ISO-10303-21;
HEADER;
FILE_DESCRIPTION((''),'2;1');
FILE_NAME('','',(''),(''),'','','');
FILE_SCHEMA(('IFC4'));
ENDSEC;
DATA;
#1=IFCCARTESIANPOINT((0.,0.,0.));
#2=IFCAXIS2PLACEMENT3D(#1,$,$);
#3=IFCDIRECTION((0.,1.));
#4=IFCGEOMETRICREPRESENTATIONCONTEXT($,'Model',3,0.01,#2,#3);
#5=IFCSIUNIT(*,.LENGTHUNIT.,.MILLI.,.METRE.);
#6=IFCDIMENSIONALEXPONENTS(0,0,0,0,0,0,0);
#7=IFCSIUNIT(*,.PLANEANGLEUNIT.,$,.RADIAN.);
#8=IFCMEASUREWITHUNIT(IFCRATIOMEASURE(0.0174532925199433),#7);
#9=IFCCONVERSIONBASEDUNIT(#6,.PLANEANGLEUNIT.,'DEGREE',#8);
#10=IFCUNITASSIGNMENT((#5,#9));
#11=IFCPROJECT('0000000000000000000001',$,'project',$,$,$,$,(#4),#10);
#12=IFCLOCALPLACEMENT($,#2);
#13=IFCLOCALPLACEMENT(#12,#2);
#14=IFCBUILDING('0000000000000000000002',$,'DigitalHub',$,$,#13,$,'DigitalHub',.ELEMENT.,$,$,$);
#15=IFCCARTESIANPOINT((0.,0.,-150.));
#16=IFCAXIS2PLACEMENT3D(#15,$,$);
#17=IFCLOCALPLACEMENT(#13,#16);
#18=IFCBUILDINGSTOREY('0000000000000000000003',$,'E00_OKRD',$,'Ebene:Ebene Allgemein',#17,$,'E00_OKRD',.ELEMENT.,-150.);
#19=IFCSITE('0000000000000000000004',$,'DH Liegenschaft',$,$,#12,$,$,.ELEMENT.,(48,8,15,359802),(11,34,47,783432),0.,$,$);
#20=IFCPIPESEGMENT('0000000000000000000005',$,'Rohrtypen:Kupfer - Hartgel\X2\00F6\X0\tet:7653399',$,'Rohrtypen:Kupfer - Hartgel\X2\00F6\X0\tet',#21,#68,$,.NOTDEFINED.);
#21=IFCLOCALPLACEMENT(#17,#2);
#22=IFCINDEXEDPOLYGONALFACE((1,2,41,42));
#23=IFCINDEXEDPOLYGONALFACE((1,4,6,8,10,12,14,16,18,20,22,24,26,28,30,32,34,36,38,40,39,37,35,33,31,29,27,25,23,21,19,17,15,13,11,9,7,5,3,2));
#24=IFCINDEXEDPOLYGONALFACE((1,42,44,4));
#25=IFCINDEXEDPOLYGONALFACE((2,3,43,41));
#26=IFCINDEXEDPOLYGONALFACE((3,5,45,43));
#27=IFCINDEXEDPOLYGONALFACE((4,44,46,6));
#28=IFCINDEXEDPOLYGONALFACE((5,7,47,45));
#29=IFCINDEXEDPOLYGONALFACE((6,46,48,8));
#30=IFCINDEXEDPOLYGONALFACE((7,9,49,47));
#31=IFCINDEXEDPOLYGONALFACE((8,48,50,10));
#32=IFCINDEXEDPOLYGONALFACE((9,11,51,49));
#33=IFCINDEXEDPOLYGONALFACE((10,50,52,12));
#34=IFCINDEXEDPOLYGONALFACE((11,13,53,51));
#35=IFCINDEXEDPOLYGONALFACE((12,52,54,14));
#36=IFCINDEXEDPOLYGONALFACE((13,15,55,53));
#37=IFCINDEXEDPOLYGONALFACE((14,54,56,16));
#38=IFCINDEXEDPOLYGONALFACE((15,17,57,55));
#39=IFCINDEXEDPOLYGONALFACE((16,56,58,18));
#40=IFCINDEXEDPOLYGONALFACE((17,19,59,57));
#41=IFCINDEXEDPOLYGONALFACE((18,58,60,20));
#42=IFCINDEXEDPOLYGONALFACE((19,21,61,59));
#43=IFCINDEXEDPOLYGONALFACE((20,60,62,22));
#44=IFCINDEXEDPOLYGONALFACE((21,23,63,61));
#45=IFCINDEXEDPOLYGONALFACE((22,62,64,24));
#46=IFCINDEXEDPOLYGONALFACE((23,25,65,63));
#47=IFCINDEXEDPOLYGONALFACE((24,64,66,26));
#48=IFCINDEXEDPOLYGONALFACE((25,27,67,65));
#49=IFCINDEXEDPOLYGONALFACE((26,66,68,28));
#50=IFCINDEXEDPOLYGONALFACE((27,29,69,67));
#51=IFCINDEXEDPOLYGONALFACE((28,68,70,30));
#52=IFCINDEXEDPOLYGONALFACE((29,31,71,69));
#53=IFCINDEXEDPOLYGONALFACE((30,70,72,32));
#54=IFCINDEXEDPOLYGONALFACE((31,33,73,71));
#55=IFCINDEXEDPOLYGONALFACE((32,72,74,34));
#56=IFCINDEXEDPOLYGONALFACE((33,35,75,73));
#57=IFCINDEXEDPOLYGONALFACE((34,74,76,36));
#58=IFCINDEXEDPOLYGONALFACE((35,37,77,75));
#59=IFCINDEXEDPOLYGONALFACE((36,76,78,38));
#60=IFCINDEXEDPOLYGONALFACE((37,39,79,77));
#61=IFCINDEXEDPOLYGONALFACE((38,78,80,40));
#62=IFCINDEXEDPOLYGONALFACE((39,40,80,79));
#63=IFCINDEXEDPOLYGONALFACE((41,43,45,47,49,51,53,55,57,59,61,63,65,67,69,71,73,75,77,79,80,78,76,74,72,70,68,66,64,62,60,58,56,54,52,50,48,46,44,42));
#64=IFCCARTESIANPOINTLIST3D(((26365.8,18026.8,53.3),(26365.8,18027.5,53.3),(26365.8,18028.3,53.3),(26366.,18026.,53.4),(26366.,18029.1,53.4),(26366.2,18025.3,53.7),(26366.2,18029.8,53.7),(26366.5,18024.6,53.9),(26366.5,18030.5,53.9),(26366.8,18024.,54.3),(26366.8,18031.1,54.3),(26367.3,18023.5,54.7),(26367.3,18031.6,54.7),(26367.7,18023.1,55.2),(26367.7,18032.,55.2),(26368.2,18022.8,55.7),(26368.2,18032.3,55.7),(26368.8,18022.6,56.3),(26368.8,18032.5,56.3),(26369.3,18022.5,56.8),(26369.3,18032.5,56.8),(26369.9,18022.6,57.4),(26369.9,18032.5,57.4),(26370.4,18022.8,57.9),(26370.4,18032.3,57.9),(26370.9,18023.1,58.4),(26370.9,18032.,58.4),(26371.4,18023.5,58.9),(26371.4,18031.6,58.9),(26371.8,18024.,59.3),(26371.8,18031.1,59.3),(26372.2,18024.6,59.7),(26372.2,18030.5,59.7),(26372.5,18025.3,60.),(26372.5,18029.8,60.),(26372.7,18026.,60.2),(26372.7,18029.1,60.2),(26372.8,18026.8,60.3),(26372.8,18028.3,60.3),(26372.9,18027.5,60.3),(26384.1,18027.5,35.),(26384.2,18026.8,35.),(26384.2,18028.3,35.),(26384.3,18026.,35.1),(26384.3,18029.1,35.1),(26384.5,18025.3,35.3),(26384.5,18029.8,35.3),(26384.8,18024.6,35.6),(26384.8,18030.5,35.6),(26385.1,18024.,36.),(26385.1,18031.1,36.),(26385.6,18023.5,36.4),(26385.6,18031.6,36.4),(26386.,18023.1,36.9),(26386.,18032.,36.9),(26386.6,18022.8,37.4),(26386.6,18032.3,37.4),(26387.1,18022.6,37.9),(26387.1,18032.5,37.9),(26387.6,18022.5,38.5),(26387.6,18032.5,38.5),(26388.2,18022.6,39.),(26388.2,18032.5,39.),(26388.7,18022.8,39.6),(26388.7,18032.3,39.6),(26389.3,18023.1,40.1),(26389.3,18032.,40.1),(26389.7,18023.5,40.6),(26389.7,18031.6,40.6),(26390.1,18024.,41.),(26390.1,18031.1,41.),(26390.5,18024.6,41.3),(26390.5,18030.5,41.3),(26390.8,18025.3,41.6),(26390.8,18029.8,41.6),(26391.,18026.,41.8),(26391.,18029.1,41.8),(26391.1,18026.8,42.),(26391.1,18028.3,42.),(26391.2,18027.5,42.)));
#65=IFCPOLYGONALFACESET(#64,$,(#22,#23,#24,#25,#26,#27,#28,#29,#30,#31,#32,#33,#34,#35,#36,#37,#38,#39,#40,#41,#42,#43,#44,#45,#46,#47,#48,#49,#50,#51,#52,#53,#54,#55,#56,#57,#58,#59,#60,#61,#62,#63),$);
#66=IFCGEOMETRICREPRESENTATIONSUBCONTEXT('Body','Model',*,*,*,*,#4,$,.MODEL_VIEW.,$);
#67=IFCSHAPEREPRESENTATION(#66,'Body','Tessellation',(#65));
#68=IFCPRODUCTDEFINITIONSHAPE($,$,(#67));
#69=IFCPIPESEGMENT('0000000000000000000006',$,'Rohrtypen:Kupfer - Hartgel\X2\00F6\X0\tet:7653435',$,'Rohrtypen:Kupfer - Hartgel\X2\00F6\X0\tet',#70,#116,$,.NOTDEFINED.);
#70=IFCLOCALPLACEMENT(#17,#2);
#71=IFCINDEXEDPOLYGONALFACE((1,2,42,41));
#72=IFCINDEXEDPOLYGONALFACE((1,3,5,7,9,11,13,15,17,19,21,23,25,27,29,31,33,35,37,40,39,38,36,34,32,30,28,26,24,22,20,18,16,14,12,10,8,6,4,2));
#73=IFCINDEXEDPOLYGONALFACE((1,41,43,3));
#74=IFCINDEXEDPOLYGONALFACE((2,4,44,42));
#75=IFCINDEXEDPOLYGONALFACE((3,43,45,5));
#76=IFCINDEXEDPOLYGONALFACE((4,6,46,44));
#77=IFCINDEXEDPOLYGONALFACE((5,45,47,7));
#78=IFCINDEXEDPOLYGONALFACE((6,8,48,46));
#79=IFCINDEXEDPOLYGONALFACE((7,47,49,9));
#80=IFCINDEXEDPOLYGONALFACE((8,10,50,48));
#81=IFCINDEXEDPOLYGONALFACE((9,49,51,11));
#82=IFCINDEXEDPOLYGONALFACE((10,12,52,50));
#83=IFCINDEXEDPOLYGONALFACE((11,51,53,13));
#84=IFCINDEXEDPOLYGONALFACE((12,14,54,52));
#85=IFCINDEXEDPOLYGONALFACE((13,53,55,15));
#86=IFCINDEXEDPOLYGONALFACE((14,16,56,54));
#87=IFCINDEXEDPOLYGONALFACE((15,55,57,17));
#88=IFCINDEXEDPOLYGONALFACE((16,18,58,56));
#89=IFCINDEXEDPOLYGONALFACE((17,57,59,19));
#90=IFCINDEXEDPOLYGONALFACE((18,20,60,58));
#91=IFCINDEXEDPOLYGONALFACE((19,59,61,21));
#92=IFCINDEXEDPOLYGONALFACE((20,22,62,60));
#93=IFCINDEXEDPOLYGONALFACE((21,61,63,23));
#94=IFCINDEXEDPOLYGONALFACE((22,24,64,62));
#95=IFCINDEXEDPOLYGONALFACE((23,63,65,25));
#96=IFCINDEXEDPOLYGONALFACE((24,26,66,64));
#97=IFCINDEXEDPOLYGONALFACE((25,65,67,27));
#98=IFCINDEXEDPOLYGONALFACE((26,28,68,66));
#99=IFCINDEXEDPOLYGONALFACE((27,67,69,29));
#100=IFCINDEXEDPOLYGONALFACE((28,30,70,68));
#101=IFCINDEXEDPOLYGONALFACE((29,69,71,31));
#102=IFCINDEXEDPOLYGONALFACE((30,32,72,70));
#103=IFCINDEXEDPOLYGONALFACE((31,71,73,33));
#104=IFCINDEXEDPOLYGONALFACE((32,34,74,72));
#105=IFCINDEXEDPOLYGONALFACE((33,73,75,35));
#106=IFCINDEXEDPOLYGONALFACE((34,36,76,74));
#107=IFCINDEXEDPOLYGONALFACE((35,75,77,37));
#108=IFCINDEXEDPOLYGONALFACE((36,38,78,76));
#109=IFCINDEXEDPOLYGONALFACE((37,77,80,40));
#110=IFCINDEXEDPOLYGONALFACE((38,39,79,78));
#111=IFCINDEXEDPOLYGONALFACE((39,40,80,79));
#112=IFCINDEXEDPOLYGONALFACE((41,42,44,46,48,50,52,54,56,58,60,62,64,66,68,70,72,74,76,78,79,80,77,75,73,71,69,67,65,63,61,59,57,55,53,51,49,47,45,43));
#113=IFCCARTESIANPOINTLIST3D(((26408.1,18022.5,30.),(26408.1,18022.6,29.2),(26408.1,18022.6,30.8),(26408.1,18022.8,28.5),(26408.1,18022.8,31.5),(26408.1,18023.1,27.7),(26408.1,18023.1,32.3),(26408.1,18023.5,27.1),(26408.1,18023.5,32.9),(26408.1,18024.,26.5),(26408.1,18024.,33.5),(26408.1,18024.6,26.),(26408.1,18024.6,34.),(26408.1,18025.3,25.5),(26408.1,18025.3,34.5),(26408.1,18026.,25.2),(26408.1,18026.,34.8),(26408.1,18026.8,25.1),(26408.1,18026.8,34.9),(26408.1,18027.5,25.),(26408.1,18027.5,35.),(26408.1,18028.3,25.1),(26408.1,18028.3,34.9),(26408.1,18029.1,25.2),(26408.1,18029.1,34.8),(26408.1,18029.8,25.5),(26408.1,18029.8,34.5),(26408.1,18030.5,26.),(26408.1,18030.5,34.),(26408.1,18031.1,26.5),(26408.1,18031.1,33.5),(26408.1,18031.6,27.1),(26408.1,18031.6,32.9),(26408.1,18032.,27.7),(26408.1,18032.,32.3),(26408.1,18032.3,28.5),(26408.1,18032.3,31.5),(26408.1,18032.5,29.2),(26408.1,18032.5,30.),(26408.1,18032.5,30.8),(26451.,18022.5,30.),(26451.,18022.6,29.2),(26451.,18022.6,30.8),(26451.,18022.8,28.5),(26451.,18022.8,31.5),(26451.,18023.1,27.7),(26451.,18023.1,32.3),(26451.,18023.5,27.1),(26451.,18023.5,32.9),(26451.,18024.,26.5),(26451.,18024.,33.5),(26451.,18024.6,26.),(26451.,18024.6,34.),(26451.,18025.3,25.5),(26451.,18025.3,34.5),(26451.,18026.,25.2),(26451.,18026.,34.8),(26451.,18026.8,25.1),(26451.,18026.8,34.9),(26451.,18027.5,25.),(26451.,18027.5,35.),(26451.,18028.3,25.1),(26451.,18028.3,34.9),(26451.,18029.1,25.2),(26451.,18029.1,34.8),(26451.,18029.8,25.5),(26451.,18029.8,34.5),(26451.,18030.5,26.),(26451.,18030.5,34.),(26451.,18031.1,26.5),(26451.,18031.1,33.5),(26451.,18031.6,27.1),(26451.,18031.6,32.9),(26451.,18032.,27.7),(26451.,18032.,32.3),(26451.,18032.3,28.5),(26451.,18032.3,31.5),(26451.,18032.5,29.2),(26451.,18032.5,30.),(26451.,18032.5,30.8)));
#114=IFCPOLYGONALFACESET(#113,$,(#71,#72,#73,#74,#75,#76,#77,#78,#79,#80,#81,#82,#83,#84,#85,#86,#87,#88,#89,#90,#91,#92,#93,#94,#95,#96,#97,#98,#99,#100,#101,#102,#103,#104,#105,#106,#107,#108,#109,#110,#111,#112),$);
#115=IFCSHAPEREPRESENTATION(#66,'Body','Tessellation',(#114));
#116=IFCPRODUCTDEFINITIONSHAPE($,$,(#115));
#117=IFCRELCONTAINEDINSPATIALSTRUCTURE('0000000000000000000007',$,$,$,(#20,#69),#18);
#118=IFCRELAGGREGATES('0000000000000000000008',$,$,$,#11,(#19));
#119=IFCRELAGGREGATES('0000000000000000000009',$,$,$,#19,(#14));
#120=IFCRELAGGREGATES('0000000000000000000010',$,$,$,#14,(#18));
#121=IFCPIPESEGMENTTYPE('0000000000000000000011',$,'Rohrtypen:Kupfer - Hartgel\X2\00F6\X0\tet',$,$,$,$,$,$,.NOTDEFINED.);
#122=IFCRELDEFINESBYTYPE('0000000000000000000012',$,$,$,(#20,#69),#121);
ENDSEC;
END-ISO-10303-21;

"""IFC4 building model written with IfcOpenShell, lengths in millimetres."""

from ifc_helpers import new_model, entity, si_unit, converted_unit, direction, frame, origin, place, context, subcontext, project, spatial, indexed_curve, outline, extrude, type_object, element, save


model = new_model("IFC4")

# Units and contexts
model_context = context("Model", 3, precision=0.01, world=origin(), true_north=direction((0.0, 1.0)))
body_context = subcontext(model_context, "Body", "Model", "MODEL_VIEW")
ifc_project = project(units=[si_unit("LENGTHUNIT", "METRE", prefix="MILLI"), converted_unit("PLANEANGLEUNIT", "DEGREE", entity("IfcRatioMeasure", 0.0174532925199433), si_unit("PLANEANGLEUNIT", "RADIAN"), dimensions=[0, 0, 0, 0, 0, 0, 0])], contexts=[model_context])

# Site, building, storey
site_placement = place(None, origin())
site = spatial("IfcSite", under=ifc_project, at=site_placement, Name="DH Liegenschaft", CompositionType="ELEMENT", RefLatitude=(48, 8, 15, 359802), RefLongitude=(11, 34, 47, 783432), RefElevation=0.0)
building_placement = place(site_placement, origin())
building = spatial("IfcBuilding", under=site, at=building_placement, Name="DigitalHub", LongName="DigitalHub", CompositionType="ELEMENT")
storey_placement = place(building_placement, frame((0.0, 0.0, -150.0)))
storey = spatial("IfcBuildingStorey", under=building, at=storey_placement, Name="E00_OKRD", ObjectType="Ebene:Ebene Allgemein", LongName="E00_OKRD", CompositionType="ELEMENT", Elevation=-150.0)

# Pipe segments
pipe_segment_type = type_object("IfcPipeSegmentType", Name="Rohrtypen:Kupfer - Hartgelötet", PredefinedType="NOTDEFINED")
pipe_segment_1_placement = place(storey_placement, frame((26364.2, 18020.9, 33.4)))
element("IfcPipeSegment", 1, at=pipe_segment_1_placement, inside=storey, type_object=pipe_segment_type, Name="Rohrtypen:Kupfer - Hartgelötet:7653399", ObjectType="Rohrtypen:Kupfer - Hartgelötet", PredefinedType="NOTDEFINED", context=body_context, shape_type="SweptSolid", body=[
    extrude(outline(indexed_curve([(5.0, 0.0), (4.9, 0.8), (4.8, 1.5), (4.5, 2.3), (4.0, 2.9), (3.5, 3.5), (2.9, 4.0), (2.3, 4.5), (1.5, 4.8), (0.8, 4.9), (0.0, 5.0), (-0.8, 4.9), (-1.5, 4.8), (-2.3, 4.5), (-2.9, 4.0), (-3.5, 3.5), (-4.0, 2.9), (-4.5, 2.3), (-4.8, 1.5), (-4.9, 0.8), (-5.0, 0.0), (-4.9, -0.8), (-4.8, -1.5), (-4.5, -2.3), (-4.0, -2.9), (-3.5, -3.5), (-2.9, -4.0), (-2.3, -4.5), (-1.5, -4.8), (-0.8, -4.9), (0.0, -5.0), (0.8, -4.9), (1.5, -4.8), (2.3, -4.5), (2.9, -4.0), (3.5, -3.5), (4.0, -2.9), (4.5, -2.3), (4.8, -1.5), (4.9, -0.8), (5.0, 0.0)], self_intersect=False)), frame((5.1, 6.6, 23.5), z_axis=(0.707107, 0.0, -0.707107), x_axis=(0.0, -1.0, 0.0)), (0.0, 0.0, 1.0), 25.9),
])
pipe_segment_2_placement = place(storey_placement, frame((26408.1, 18020.9, 23.4)))
element("IfcPipeSegment", 2, at=pipe_segment_2_placement, inside=storey, type_object=pipe_segment_type, Name="Rohrtypen:Kupfer - Hartgelötet:7653435", ObjectType="Rohrtypen:Kupfer - Hartgelötet", PredefinedType="NOTDEFINED", context=body_context, shape_type="SweptSolid", body=[
    extrude(outline(indexed_curve([(5.0, 0.0), (4.9, 0.8), (4.8, 1.5), (4.5, 2.3), (4.0, 2.9), (3.5, 3.5), (2.9, 4.0), (2.3, 4.5), (1.5, 4.8), (0.8, 4.9), (0.0, 5.0), (-0.8, 4.9), (-1.5, 4.8), (-2.3, 4.5), (-2.9, 4.0), (-3.5, 3.5), (-4.0, 2.9), (-4.5, 2.3), (-4.8, 1.5), (-4.9, 0.8), (-5.0, 0.0), (-4.9, -0.8), (-4.8, -1.5), (-4.5, -2.3), (-4.0, -2.9), (-3.5, -3.5), (-2.9, -4.0), (-2.3, -4.5), (-1.5, -4.8), (-0.8, -4.9), (0.0, -5.0), (0.8, -4.9), (1.5, -4.8), (2.3, -4.5), (2.9, -4.0), (3.5, -3.5), (4.0, -2.9), (4.5, -2.3), (4.8, -1.5), (4.9, -0.8), (5.0, 0.0)], self_intersect=False)), frame((0.0, 6.6, 6.6), z_axis=(1.0, 0.0, 0.0), x_axis=(0.0, -1.0, 0.0)), (0.0, 0.0, 1.0), 42.8),
])

save(model, "model.ifc")
